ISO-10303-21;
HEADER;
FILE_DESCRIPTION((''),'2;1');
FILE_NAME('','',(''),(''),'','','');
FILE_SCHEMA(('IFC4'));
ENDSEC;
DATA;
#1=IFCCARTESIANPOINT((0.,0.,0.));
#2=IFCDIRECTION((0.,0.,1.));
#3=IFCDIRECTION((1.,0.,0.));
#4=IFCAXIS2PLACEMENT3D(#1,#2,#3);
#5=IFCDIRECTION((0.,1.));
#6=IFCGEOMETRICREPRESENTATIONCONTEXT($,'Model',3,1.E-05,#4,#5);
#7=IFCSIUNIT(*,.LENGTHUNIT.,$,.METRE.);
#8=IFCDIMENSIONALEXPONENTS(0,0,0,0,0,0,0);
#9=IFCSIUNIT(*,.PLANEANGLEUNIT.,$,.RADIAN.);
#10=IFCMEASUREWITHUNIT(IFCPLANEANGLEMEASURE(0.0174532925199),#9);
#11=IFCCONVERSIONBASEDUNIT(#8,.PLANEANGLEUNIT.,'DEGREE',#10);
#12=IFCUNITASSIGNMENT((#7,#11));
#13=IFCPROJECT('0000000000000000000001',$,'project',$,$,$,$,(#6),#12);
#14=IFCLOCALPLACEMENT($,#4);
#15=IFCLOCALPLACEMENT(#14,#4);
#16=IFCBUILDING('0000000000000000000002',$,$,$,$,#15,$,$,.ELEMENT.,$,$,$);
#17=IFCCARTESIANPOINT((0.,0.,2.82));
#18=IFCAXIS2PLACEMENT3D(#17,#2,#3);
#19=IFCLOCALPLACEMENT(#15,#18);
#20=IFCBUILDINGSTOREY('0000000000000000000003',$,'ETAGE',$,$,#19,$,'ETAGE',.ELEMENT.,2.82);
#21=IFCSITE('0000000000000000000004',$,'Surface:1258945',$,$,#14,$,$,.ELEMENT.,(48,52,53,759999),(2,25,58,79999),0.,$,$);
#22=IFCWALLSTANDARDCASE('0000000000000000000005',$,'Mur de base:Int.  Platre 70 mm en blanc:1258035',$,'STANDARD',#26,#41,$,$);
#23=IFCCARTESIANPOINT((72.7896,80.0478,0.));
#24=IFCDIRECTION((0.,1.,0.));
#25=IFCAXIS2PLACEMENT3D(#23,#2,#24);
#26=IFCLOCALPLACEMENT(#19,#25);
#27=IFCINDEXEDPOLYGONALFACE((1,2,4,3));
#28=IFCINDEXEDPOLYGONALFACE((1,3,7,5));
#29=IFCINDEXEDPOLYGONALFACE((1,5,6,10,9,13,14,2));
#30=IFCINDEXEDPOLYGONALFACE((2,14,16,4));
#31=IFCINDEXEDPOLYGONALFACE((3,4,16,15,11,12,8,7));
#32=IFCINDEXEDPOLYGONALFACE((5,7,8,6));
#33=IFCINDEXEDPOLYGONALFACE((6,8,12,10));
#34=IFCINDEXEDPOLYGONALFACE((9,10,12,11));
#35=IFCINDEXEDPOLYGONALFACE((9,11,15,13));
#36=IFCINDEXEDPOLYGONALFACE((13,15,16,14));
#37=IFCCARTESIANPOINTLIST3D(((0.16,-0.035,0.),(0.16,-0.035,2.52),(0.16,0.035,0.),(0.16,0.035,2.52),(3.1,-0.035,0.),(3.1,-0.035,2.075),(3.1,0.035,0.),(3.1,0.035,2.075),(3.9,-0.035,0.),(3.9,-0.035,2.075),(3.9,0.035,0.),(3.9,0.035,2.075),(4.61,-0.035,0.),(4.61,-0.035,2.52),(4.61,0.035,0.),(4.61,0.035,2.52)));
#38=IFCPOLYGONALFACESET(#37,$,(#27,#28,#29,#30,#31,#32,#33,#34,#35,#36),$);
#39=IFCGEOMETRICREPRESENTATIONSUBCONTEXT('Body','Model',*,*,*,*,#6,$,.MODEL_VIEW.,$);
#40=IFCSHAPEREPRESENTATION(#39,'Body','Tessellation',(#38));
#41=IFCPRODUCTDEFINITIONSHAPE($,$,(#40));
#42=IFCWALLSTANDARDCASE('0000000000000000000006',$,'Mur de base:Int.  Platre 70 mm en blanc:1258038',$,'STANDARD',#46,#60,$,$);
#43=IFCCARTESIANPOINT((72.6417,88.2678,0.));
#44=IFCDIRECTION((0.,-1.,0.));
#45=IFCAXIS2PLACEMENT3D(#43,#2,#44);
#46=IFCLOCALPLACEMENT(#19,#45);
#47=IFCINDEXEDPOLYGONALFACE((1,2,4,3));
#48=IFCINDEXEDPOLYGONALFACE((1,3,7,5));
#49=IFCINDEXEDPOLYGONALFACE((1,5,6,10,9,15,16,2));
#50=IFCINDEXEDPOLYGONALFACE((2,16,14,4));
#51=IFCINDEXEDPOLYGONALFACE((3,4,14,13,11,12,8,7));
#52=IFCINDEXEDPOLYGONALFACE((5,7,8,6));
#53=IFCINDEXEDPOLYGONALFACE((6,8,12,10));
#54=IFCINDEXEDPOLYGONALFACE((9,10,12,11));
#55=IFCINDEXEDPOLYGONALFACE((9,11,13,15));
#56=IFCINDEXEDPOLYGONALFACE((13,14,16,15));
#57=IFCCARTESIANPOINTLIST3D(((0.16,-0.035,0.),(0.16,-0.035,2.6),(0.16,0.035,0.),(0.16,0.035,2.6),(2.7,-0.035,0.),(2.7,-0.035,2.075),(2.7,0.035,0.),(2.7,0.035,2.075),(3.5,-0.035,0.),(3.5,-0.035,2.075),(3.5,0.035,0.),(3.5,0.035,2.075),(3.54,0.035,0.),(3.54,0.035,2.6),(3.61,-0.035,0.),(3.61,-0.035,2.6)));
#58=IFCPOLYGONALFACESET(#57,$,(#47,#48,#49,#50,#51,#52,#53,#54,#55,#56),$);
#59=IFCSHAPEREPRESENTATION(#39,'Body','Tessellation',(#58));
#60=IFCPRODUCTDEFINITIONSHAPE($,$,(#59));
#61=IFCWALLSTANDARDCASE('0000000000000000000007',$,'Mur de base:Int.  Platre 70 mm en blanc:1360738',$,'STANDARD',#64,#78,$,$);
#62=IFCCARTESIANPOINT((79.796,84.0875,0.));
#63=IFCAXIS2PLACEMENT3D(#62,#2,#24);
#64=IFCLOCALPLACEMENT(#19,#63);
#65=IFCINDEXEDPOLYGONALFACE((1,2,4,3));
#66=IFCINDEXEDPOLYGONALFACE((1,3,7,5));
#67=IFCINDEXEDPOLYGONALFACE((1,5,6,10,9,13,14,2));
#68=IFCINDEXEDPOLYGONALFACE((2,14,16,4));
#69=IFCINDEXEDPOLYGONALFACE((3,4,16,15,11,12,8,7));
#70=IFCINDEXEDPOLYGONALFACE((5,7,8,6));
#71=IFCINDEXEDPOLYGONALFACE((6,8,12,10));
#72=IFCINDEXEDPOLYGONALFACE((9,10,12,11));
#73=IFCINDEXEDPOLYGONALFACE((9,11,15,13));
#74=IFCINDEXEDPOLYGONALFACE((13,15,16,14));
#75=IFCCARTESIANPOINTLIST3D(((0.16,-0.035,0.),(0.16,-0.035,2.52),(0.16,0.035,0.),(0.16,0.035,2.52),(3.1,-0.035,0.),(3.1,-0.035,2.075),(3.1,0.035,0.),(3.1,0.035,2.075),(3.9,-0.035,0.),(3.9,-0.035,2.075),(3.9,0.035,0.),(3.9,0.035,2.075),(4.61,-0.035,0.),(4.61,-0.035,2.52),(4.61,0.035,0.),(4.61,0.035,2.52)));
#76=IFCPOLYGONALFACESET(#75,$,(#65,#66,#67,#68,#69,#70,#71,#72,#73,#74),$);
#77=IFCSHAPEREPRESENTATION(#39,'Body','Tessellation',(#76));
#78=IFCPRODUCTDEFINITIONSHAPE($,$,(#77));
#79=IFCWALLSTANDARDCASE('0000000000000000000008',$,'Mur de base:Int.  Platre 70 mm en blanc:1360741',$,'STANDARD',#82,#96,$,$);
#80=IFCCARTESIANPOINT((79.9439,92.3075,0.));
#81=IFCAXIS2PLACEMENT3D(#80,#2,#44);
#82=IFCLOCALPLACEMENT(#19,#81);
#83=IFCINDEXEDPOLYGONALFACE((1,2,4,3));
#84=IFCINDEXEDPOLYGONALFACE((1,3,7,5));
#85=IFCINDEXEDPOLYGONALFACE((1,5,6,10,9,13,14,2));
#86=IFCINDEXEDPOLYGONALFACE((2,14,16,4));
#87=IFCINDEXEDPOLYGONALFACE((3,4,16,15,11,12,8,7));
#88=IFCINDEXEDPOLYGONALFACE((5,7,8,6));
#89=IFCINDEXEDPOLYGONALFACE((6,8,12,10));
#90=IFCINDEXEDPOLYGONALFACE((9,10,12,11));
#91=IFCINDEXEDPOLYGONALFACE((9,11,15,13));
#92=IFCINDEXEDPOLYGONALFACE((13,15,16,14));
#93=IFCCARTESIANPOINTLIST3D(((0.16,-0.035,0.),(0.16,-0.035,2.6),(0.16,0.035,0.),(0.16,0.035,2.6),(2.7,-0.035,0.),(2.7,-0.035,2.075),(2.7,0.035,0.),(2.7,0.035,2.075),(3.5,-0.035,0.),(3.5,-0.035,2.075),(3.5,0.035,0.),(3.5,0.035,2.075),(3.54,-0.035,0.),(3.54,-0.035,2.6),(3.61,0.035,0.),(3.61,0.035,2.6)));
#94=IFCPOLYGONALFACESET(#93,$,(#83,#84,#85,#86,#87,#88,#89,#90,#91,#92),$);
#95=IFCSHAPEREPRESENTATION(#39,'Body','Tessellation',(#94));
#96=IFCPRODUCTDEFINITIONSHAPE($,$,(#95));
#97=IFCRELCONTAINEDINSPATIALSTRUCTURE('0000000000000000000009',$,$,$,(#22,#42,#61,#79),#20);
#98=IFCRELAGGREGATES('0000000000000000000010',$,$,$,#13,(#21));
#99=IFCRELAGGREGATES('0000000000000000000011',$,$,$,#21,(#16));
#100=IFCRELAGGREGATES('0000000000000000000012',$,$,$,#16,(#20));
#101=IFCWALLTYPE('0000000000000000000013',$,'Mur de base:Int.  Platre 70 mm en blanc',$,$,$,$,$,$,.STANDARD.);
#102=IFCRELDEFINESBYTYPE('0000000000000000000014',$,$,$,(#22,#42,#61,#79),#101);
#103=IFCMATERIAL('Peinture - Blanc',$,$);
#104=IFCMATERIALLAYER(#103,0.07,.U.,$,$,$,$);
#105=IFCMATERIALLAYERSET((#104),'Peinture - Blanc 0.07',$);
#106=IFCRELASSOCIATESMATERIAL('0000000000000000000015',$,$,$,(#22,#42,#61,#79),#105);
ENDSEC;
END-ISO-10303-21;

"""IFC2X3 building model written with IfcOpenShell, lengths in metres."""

from ifc_helpers import new_model, entity, si_unit, converted_unit, direction, frame, origin_with_axes, place, context, subcontext, project, spatial, polyline, outline, extrude, material, layer, layer_set, layer_usage, type_object, element, save


model = new_model("IFC2X3")

# Units and contexts
model_context = context("Model", 3, precision=1e-05, world=origin_with_axes(), true_north=direction((0.0, 1.0)))
body_context = subcontext(model_context, "Body", "Model", "MODEL_VIEW")
ifc_project = project(units=[si_unit("LENGTHUNIT", "METRE"), converted_unit("PLANEANGLEUNIT", "DEGREE", entity("IfcPlaneAngleMeasure", 0.0174532925199), si_unit("PLANEANGLEUNIT", "RADIAN"), dimensions=[0, 0, 0, 0, 0, 0, 0])], contexts=[model_context])

# Site, building, storey
site_placement = place(None, origin_with_axes())
site = spatial("IfcSite", under=ifc_project, at=site_placement, Name="Surface:1258945", CompositionType="ELEMENT", RefLatitude=(48, 52, 53, 759999), RefLongitude=(2, 25, 58, 79999), RefElevation=0.0)
building_placement = place(site_placement, origin_with_axes())
building = spatial("IfcBuilding", under=site, at=building_placement, CompositionType="ELEMENT")
storey_placement = place(building_placement, frame((0.0, 0.0, 2.82), z_axis=(0.0, 0.0, 1.0), x_axis=(1.0, 0.0, 0.0)))
storey = spatial("IfcBuildingStorey", under=building, at=storey_placement, Name="ETAGE", LongName="ETAGE", CompositionType="ELEMENT", Elevation=2.82)

# Walls, openings
ifc_material_1 = material(Name="Peinture - Blanc")
ifc_layer_1 = layer(ifc_material_1, 0.07, ventilated="UNKNOWN")
ifc_layer_set_1 = layer_set([ifc_layer_1], Name="Peinture - Blanc 0.07")
ifc_layer_usage_1 = layer_usage(ifc_layer_set_1, "AXIS2", "POSITIVE", -0.035)
wall_type_1 = type_object("IfcWallType", Name="Mur de base:Int.  Platre 70 mm en blanc", PredefinedType="STANDARD")
wall_1_placement = place(storey_placement, frame((72.7896, 80.0478, 0.0), z_axis=(0.0, 0.0, 1.0), x_axis=(0.0, 1.0, 0.0)))
wall_1 = element("IfcWallStandardCase", 1, at=wall_1_placement, inside=storey, type_object=wall_type_1, material=ifc_layer_usage_1, Name="Mur de base:Int.  Platre 70 mm en blanc:1258035", ObjectType="STANDARD", context=body_context, shape_type="SweptSolid", body=[
    extrude(outline(polyline([(0.16, -0.035), (4.61, -0.035), (4.61, 0.035), (0.16, 0.035), (0.16, -0.035)])), origin_with_axes(), (0.0, 0.0, 1.0), 2.52),
])
opening_1_placement = place(wall_1_placement, frame((3.5, 0.0, 0.0), z_axis=(0.0, 0.0, 1.0), x_axis=(1.0, 0.0, 0.0)))
element("IfcOpeningElement", 2, at=opening_1_placement, cuts=wall_1, context=body_context, shape_type="SweptSolid", body=[
    extrude(outline(polyline([(-0.4, 0.0), (0.4, 0.0), (0.4, 2.075), (-0.4, 2.075), (-0.4, 0.0)])), frame((0.0, 0.035, 0.0), z_axis=(0.0, 1.0, 0.0), x_axis=(-1.0, 0.0, 0.0)), (0.0, 0.0, -1.0), 0.07),
])
ifc_layer_usage_2 = layer_usage(ifc_layer_set_1, "AXIS2", "POSITIVE", -0.035)
wall_2_placement = place(storey_placement, frame((72.6417, 88.2678, 0.0), z_axis=(0.0, 0.0, 1.0), x_axis=(0.0, -1.0, 0.0)))
wall_2 = element("IfcWallStandardCase", 3, at=wall_2_placement, inside=storey, type_object=wall_type_1, material=ifc_layer_usage_2, Name="Mur de base:Int.  Platre 70 mm en blanc:1258038", ObjectType="STANDARD", context=body_context, shape_type="SweptSolid", body=[
    extrude(outline(polyline([(0.16, -0.035), (3.61, -0.035), (3.54, 0.035), (0.16, 0.035), (0.16, -0.035)])), origin_with_axes(), (0.0, 0.0, 1.0), 2.6),
])
opening_2_placement = place(wall_2_placement, frame((3.1, 0.0, 0.0), z_axis=(0.0, 0.0, 1.0), x_axis=(1.0, 0.0, 0.0)))
element("IfcOpeningElement", 4, at=opening_2_placement, cuts=wall_2, context=body_context, shape_type="SweptSolid", body=[
    extrude(outline(polyline([(0.4, 0.0), (0.4, 2.075), (-0.4, 2.075), (-0.4, 0.0), (0.4, 0.0)])), frame((0.0, -0.035, 0.0), z_axis=(0.0, 1.0, 0.0), x_axis=(-1.0, 0.0, 0.0)), (0.0, 0.0, 1.0), 0.07),
])

# Walls, openings
ifc_layer_usage_3 = layer_usage(ifc_layer_set_1, "AXIS2", "POSITIVE", -0.035)
wall_3_placement = place(storey_placement, frame((79.796, 84.0875, 0.0), z_axis=(0.0, 0.0, 1.0), x_axis=(0.0, 1.0, 0.0)))
wall_3 = element("IfcWallStandardCase", 5, at=wall_3_placement, inside=storey, type_object=wall_type_1, material=ifc_layer_usage_3, Name="Mur de base:Int.  Platre 70 mm en blanc:1360738", ObjectType="STANDARD", context=body_context, shape_type="SweptSolid", body=[
    extrude(outline(polyline([(0.16, -0.035), (4.61, -0.035), (4.61, 0.035), (0.16, 0.035), (0.16, -0.035)])), origin_with_axes(), (0.0, 0.0, 1.0), 2.52),
])
opening_3_placement = place(wall_3_placement, frame((3.5, 0.0, 0.0), z_axis=(0.0, 0.0, 1.0), x_axis=(1.0, 0.0, 0.0)))
element("IfcOpeningElement", 6, at=opening_3_placement, cuts=wall_3, context=body_context, shape_type="SweptSolid", body=[
    extrude(outline(polyline([(0.4, 0.0), (0.4, 2.075), (-0.4, 2.075), (-0.4, 0.0), (0.4, 0.0)])), frame((0.0, -0.035, 0.0), z_axis=(0.0, 1.0, 0.0), x_axis=(-1.0, 0.0, 0.0)), (0.0, 0.0, 1.0), 0.07),
])
ifc_layer_usage_4 = layer_usage(ifc_layer_set_1, "AXIS2", "POSITIVE", -0.035)
wall_4_placement = place(storey_placement, frame((79.9439, 92.3075, 0.0), z_axis=(0.0, 0.0, 1.0), x_axis=(0.0, -1.0, 0.0)))
wall_4 = element("IfcWallStandardCase", 7, at=wall_4_placement, inside=storey, type_object=wall_type_1, material=ifc_layer_usage_4, Name="Mur de base:Int.  Platre 70 mm en blanc:1360741", ObjectType="STANDARD", context=body_context, shape_type="SweptSolid", body=[
    extrude(outline(polyline([(0.16, -0.035), (3.54, -0.035), (3.61, 0.035), (0.16, 0.035), (0.16, -0.035)])), origin_with_axes(), (0.0, 0.0, 1.0), 2.6),
])
opening_4_placement = place(wall_4_placement, frame((3.1, 0.0, 0.0), z_axis=(0.0, 0.0, 1.0), x_axis=(1.0, 0.0, 0.0)))
element("IfcOpeningElement", 8, at=opening_4_placement, cuts=wall_4, context=body_context, shape_type="SweptSolid", body=[
    extrude(outline(polyline([(-0.4, 0.0), (0.4, 0.0), (0.4, 2.075), (-0.4, 2.075), (-0.4, 0.0)])), frame((0.0, 0.035, 0.0), z_axis=(0.0, 1.0, 0.0), x_axis=(-1.0, 0.0, 0.0)), (0.0, 0.0, -1.0), 0.07),
])

save(model, "model.ifc")
